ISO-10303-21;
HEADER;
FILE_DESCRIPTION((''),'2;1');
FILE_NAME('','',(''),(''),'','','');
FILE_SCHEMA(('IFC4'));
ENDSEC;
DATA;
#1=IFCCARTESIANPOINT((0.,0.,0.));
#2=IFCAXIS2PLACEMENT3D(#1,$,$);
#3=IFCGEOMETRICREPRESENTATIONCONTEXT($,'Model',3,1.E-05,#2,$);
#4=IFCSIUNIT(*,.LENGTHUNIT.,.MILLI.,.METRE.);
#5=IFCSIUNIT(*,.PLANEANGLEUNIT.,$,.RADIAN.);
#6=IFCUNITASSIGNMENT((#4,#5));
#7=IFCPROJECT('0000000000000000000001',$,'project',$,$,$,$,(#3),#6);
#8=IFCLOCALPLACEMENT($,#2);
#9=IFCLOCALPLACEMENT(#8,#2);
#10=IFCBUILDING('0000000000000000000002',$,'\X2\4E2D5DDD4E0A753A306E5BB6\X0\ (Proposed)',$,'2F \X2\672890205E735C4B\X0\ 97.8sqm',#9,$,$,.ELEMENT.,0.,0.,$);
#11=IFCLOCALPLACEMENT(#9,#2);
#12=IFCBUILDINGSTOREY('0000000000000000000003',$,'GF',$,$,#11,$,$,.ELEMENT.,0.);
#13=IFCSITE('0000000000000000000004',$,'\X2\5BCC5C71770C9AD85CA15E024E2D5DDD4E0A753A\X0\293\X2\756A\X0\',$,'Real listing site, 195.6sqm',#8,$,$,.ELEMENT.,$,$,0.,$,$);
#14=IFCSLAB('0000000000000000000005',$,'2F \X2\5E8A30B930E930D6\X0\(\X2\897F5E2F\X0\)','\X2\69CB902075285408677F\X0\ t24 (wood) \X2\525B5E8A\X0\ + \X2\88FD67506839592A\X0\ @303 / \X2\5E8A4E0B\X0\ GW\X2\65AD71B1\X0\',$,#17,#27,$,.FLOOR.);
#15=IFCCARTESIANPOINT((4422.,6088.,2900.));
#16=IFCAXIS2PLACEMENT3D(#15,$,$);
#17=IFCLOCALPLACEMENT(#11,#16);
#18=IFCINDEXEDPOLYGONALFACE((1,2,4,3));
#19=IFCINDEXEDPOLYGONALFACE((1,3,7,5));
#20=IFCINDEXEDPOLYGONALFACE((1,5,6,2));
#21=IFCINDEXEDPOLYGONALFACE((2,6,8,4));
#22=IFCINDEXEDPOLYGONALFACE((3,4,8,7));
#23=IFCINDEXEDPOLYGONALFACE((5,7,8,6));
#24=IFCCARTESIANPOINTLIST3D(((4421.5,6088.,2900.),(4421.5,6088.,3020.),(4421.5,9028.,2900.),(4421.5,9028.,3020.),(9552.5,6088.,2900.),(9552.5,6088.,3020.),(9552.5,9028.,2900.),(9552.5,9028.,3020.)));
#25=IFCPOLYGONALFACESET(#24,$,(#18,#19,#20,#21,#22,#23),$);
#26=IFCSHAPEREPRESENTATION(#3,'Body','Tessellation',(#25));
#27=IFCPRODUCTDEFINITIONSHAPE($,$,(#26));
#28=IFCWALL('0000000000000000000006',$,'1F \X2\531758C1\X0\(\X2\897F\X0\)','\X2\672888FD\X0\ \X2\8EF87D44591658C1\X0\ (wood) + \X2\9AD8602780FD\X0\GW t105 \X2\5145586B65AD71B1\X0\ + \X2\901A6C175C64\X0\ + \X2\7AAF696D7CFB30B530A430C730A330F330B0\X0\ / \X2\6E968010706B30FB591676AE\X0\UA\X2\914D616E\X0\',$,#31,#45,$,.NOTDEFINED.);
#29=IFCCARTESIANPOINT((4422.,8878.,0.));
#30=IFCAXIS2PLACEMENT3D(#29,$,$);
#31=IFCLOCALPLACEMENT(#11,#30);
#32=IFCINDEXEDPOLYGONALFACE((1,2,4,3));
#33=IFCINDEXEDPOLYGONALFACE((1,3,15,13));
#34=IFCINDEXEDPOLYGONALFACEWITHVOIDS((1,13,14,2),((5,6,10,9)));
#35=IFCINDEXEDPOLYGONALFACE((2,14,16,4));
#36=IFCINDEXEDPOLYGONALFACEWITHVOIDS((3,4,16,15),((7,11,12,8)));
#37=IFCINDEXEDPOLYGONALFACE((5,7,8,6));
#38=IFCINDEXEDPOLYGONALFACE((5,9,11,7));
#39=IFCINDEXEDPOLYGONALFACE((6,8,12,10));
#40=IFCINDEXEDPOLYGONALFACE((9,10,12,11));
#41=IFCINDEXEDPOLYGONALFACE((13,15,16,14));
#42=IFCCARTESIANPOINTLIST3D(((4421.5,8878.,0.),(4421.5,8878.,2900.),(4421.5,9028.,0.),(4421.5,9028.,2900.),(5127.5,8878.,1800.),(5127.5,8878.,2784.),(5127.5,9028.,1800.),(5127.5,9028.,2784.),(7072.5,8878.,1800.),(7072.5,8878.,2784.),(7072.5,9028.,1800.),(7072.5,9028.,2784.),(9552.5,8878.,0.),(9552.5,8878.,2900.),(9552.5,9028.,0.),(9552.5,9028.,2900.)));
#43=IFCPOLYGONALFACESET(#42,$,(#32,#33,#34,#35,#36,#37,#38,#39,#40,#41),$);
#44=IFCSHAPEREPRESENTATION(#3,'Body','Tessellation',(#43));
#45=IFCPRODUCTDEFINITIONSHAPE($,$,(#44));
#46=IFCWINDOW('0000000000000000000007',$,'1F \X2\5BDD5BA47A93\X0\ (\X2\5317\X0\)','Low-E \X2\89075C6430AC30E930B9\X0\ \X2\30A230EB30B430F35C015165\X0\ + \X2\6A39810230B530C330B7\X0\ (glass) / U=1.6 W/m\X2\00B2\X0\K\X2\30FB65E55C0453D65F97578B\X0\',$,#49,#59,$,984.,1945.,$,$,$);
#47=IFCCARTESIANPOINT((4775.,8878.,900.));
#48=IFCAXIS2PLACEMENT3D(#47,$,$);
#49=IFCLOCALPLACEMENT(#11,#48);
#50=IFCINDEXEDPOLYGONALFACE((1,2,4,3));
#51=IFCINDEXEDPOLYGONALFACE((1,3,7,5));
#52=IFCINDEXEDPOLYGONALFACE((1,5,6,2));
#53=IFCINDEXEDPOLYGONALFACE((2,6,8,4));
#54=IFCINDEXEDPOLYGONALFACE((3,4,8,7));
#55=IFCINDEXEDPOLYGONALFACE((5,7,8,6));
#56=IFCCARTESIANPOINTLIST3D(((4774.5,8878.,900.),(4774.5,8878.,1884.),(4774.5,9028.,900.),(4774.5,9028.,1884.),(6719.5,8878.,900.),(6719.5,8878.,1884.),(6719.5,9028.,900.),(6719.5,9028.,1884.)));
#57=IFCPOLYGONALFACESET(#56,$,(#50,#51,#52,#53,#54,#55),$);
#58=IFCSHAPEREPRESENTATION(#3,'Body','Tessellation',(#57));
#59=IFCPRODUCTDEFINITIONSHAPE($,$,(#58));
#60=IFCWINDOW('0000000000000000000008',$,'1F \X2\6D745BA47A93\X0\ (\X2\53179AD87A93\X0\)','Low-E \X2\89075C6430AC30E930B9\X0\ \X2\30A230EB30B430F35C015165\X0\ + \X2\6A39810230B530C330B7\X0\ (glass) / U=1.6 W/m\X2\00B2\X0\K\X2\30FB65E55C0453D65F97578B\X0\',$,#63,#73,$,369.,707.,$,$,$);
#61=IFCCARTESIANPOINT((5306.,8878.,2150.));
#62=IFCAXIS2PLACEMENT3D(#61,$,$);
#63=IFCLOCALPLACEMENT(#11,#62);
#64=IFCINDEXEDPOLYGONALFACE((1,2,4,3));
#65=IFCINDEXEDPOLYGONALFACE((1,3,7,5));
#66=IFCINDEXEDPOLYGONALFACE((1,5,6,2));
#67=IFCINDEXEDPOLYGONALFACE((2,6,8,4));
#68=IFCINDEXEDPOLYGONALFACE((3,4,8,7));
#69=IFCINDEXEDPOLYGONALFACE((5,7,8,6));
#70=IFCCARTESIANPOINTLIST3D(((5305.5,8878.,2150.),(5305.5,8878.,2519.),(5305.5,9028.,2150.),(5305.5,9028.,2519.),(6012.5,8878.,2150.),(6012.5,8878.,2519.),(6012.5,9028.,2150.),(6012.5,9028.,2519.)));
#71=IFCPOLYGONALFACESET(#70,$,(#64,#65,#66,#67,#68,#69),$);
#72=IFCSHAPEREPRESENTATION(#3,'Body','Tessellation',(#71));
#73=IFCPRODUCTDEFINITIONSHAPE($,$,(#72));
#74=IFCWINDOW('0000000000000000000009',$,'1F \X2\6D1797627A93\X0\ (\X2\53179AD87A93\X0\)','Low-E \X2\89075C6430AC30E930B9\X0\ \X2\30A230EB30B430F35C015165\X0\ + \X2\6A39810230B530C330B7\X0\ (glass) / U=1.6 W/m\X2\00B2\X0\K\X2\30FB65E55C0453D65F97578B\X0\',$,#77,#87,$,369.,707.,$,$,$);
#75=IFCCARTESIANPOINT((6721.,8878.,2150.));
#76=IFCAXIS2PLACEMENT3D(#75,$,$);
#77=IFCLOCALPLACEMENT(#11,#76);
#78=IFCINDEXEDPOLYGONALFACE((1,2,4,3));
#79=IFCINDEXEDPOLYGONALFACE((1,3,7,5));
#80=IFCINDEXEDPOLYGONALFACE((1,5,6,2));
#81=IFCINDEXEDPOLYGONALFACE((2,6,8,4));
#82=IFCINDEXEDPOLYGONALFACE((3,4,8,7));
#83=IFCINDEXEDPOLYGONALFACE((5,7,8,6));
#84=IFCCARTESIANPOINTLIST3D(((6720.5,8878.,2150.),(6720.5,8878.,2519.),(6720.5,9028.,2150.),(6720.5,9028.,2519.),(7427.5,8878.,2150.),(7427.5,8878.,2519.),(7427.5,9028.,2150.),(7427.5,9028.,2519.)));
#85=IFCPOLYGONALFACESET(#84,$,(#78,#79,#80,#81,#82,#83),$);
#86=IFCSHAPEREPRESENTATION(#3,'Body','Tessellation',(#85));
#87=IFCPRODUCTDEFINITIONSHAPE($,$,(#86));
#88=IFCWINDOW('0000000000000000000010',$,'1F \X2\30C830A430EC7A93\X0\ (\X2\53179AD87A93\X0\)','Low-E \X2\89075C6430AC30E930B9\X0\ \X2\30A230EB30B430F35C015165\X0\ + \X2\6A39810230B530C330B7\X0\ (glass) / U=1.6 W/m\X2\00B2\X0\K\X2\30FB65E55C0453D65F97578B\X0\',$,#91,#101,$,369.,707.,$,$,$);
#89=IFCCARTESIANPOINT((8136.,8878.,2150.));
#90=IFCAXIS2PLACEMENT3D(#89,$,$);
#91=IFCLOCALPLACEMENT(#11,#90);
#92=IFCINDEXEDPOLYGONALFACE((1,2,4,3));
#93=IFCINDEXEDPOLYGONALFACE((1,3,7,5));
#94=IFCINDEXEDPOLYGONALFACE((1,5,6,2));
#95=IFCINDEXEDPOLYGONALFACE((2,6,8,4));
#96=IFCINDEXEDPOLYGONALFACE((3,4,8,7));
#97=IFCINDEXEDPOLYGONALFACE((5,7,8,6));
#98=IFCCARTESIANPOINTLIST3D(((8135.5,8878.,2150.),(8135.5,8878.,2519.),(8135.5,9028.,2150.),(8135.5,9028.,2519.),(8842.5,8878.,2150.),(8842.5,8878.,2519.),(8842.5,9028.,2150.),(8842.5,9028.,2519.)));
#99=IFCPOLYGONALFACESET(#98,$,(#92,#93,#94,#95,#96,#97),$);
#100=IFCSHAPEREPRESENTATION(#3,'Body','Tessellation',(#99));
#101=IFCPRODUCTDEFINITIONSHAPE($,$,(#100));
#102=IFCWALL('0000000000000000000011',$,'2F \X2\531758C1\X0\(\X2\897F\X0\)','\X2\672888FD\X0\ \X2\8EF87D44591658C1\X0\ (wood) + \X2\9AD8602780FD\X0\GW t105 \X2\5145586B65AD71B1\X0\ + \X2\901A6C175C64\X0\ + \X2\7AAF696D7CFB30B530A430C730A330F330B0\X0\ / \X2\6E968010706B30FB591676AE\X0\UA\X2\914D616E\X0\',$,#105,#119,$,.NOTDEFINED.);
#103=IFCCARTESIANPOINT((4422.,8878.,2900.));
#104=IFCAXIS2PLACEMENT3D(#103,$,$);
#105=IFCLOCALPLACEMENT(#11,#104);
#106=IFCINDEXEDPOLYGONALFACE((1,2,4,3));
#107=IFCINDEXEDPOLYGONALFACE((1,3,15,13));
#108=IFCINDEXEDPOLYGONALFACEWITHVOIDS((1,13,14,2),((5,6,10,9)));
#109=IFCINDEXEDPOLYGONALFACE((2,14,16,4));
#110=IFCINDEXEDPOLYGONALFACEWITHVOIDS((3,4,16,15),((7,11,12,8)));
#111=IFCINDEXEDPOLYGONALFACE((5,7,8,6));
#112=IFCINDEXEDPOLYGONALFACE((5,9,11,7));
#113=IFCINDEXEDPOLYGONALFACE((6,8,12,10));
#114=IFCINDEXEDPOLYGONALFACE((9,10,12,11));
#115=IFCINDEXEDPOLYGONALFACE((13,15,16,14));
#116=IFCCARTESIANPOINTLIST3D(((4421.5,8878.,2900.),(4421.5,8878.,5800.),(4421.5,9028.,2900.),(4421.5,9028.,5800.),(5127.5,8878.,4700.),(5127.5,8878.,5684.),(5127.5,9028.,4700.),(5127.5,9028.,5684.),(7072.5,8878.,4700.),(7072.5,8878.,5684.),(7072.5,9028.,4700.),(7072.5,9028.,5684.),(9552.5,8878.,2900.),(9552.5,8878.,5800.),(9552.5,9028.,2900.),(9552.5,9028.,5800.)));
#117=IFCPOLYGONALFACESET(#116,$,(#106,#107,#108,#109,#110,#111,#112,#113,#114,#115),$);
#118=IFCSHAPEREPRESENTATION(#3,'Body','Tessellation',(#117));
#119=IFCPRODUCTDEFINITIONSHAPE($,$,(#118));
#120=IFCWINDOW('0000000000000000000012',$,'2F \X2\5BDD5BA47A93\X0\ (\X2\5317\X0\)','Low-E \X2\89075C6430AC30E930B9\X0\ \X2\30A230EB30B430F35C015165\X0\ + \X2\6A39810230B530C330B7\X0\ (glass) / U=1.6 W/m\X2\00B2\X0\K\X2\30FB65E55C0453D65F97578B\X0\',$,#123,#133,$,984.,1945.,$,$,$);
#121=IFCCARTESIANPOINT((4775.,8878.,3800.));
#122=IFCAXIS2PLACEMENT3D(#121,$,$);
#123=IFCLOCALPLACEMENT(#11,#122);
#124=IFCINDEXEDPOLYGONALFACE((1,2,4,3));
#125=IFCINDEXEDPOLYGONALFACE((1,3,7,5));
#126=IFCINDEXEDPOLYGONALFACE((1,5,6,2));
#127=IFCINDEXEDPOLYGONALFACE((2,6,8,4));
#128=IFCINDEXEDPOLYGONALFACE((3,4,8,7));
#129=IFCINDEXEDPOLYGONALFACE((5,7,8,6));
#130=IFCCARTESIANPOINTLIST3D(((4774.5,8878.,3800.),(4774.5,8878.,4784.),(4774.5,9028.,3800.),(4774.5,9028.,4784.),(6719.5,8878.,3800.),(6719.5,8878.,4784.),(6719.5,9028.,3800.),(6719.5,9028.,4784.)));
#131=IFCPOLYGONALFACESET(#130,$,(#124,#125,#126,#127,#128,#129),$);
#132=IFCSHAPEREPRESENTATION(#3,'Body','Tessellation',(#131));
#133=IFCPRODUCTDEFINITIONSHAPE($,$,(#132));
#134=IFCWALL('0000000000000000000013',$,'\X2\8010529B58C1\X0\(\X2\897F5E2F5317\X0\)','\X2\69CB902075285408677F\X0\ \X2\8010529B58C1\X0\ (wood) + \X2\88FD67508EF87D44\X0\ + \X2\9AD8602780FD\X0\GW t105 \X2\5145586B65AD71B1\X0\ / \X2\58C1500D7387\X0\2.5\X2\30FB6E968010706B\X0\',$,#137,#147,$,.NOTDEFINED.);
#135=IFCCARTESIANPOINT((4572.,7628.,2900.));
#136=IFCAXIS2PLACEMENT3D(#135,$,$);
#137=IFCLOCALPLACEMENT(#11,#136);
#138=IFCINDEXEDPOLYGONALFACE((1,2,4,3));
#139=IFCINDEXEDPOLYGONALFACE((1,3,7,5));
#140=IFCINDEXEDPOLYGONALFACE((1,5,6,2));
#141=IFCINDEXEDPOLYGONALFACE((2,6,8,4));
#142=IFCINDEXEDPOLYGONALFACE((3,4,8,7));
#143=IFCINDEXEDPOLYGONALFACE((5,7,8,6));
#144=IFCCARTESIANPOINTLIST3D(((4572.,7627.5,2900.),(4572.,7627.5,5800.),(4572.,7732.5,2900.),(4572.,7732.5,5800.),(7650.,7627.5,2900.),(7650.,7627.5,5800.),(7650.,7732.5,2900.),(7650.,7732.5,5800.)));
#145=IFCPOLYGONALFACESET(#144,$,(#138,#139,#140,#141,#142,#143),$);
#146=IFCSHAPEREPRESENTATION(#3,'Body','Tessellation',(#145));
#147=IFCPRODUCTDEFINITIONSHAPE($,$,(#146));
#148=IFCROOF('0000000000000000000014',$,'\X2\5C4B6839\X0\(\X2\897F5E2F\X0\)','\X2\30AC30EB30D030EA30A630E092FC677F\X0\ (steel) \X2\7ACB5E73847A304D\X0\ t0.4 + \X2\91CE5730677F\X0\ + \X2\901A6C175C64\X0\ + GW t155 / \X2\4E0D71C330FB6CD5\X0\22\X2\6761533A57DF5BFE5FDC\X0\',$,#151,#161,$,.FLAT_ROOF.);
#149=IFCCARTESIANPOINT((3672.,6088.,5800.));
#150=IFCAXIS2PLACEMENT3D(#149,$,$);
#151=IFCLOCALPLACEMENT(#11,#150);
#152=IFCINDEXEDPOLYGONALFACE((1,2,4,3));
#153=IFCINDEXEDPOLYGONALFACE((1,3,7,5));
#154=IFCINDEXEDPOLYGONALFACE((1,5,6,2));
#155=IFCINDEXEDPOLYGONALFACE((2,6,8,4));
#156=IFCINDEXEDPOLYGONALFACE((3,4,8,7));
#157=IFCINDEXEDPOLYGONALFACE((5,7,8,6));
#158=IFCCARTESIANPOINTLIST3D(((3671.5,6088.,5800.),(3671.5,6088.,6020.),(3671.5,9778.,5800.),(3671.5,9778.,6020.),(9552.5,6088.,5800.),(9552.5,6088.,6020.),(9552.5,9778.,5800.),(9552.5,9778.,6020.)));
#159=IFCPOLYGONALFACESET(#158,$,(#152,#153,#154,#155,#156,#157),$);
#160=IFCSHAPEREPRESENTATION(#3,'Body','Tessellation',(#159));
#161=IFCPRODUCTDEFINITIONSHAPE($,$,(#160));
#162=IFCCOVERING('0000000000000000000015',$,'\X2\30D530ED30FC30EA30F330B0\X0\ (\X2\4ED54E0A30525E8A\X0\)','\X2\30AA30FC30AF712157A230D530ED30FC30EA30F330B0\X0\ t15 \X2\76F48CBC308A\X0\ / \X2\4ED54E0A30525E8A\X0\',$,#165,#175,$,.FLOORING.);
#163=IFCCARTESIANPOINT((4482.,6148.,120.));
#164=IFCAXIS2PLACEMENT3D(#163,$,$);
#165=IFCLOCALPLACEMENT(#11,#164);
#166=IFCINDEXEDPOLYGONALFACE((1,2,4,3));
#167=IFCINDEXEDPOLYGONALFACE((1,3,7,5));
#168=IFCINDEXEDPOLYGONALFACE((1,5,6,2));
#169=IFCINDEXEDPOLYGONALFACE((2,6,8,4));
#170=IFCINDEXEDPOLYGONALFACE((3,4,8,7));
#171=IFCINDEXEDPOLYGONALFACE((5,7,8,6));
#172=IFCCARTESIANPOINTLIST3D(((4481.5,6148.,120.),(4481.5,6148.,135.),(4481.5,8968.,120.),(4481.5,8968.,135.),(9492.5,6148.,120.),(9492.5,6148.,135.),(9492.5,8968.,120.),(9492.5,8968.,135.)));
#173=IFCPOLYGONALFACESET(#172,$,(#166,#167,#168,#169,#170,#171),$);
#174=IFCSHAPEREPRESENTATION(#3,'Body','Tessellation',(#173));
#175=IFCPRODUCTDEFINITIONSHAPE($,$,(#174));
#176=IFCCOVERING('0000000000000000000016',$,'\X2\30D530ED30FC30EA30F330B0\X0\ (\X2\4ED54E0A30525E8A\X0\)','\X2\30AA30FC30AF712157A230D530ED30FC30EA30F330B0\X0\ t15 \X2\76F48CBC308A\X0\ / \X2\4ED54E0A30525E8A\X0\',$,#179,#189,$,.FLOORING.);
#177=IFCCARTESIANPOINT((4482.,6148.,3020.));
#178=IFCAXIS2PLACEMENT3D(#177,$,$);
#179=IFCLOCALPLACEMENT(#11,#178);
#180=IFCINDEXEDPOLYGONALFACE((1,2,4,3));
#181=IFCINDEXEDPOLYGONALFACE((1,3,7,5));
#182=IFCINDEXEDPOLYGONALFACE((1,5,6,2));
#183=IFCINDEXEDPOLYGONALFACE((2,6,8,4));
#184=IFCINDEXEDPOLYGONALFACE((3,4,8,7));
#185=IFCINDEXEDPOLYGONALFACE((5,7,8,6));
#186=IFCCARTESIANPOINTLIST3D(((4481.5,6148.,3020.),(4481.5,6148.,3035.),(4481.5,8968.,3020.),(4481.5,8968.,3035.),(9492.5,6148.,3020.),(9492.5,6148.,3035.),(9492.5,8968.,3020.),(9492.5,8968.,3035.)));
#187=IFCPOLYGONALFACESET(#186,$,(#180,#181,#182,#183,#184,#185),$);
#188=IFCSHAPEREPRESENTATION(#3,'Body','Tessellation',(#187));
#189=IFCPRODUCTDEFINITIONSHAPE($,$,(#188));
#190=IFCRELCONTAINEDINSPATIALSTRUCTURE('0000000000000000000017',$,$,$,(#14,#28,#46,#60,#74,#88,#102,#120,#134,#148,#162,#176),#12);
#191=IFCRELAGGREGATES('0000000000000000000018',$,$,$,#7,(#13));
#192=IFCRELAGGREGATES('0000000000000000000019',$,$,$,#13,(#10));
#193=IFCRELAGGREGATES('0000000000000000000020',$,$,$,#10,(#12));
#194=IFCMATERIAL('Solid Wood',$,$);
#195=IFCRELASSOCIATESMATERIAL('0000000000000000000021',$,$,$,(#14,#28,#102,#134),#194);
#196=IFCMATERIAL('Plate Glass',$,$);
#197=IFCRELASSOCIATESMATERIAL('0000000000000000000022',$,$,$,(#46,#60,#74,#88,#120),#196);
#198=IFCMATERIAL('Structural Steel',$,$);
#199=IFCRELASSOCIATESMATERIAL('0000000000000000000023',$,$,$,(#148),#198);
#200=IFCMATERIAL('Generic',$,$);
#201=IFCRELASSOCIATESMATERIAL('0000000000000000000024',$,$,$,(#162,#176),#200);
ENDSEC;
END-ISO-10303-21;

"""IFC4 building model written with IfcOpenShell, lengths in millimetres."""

from ifc_helpers import new_model, si_unit, frame, frame_2d, origin, place, context, project, spatial, rectangle, extrude, material, element, fill, save


model = new_model("IFC4")

# Units and contexts
model_context = context("Model", 3, precision=1e-05, world=origin())
ifc_project = project(units=[si_unit("LENGTHUNIT", "METRE", prefix="MILLI"), si_unit("PLANEANGLEUNIT", "RADIAN")], contexts=[model_context])

# Site, building, storey
site_placement = place(None, origin())
site = spatial("IfcSite", under=ifc_project, at=site_placement, Name="富山県高岡市中川上町293番", ObjectType="Real listing site, 195.6sqm", CompositionType="ELEMENT", RefElevation=0.0)
building_placement = place(site_placement, origin())
building = spatial("IfcBuilding", under=site, at=building_placement, Name="中川上町の家 (Proposed)", ObjectType="2F 木造平屋 97.8sqm", CompositionType="ELEMENT", ElevationOfRefHeight=0.0, ElevationOfTerrain=0.0)
storey_placement = place(building_placement, origin())
storey = spatial("IfcBuildingStorey", under=building, at=storey_placement, Name="GF", CompositionType="ELEMENT", Elevation=0.0)

# Slab
ifc_material_1 = material(Name="Solid Wood")
slab_1_placement = place(storey_placement, frame((4422.0, 6088.0, 2900.0)))
element("IfcSlab", 1, at=slab_1_placement, inside=storey, material=ifc_material_1, Name="2F 床スラブ(西帯)", Description="構造用合板 t24 (wood) 剛床 + 製材根太 @303 / 床下 GW断熱", PredefinedType="FLOOR", context=model_context, shape_type="SweptSolid", body=[
    extrude(rectangle(XDim=5131.0, YDim=2940.0, at=frame_2d((2565.0, 1470.0))), frame((4422.0, 6088.0, 2900.0)), (0.0, 0.0, 1.0), 120.0),
])

# Wall, openings, windows
wall_1_placement = place(storey_placement, frame((4422.0, 8878.0, 0.0)))
wall_1 = element("IfcWall", 2, at=wall_1_placement, inside=storey, material=ifc_material_1, Name="1F 北壁(西)", Description="木製 軸組外壁 (wood) + 高性能GW t105 充填断熱 + 通気層 + 窯業系サイディング / 準耐火・外皮UA配慮", PredefinedType="NOTDEFINED", context=model_context, shape_type="SweptSolid", body=[
    extrude(rectangle(XDim=5131.0, YDim=150.0, at=frame_2d((2565.0, 75.0))), frame((4422.0, 8878.0, 0.0)), (0.0, 0.0, 1.0), 2900.0),
])
opening_1_placement = place(storey_placement, frame((4775.0, 8878.0, 900.0)))
opening_1 = element("IfcOpeningElement", 3, at=opening_1_placement, cuts=wall_1, PredefinedType="NOTDEFINED", context=model_context, shape_type="SweptSolid", body=[
    extrude(rectangle(XDim=1945.0, YDim=150.0, at=frame_2d((972.0, 75.0))), frame((4775.0, 8878.0, 900.0)), (0.0, 0.0, 1.0), 984.0),
])
opening_2_placement = place(storey_placement, frame((5306.0, 8878.0, 2150.0)))
opening_2 = element("IfcOpeningElement", 4, at=opening_2_placement, cuts=wall_1, PredefinedType="NOTDEFINED", context=model_context, shape_type="SweptSolid", body=[
    extrude(rectangle(XDim=707.0, YDim=150.0, at=frame_2d((353.0, 75.0))), frame((5306.0, 8878.0, 2150.0)), (0.0, 0.0, 1.0), 369.0),
])
opening_3_placement = place(storey_placement, frame((6721.0, 8878.0, 2150.0)))
opening_3 = element("IfcOpeningElement", 5, at=opening_3_placement, cuts=wall_1, PredefinedType="NOTDEFINED", context=model_context, shape_type="SweptSolid", body=[
    extrude(rectangle(XDim=707.0, YDim=150.0, at=frame_2d((353.0, 75.0))), frame((6721.0, 8878.0, 2150.0)), (0.0, 0.0, 1.0), 369.0),
])
opening_4_placement = place(storey_placement, frame((8136.0, 8878.0, 2150.0)))
opening_4 = element("IfcOpeningElement", 6, at=opening_4_placement, cuts=wall_1, PredefinedType="NOTDEFINED", context=model_context, shape_type="SweptSolid", body=[
    extrude(rectangle(XDim=707.0, YDim=150.0, at=frame_2d((353.0, 75.0))), frame((8136.0, 8878.0, 2150.0)), (0.0, 0.0, 1.0), 369.0),
])
ifc_material_2 = material(Name="Plate Glass")
window_1_placement = place(storey_placement, frame((4775.0, 8878.0, 900.0)))
window_1 = element("IfcWindow", 7, at=window_1_placement, inside=storey, material=ifc_material_2, Name="1F 寝室窓 (北)", Description="Low-E 複層ガラス アルゴン封入 + 樹脂サッシ (glass) / U=1.6 W/m²K・日射取得型", OverallHeight=984.0, OverallWidth=1945.0, context=model_context, shape_type="SweptSolid", body=[
    extrude(rectangle(XDim=1945.0, YDim=150.0, at=frame_2d((972.0, 75.0))), frame((4775.0, 8878.0, 900.0)), (0.0, 0.0, 1.0), 984.0),
])
fill(opening_1, window_1)
window_2_placement = place(storey_placement, frame((5306.0, 8878.0, 2150.0)))
window_2 = element("IfcWindow", 8, at=window_2_placement, inside=storey, material=ifc_material_2, Name="1F 浴室窓 (北高窓)", Description="Low-E 複層ガラス アルゴン封入 + 樹脂サッシ (glass) / U=1.6 W/m²K・日射取得型", OverallHeight=369.0, OverallWidth=707.0, context=model_context, shape_type="SweptSolid", body=[
    extrude(rectangle(XDim=707.0, YDim=150.0, at=frame_2d((353.0, 75.0))), frame((5306.0, 8878.0, 2150.0)), (0.0, 0.0, 1.0), 369.0),
])
fill(opening_2, window_2)
window_3_placement = place(storey_placement, frame((6721.0, 8878.0, 2150.0)))
window_3 = element("IfcWindow", 9, at=window_3_placement, inside=storey, material=ifc_material_2, Name="1F 洗面窓 (北高窓)", Description="Low-E 複層ガラス アルゴン封入 + 樹脂サッシ (glass) / U=1.6 W/m²K・日射取得型", OverallHeight=369.0, OverallWidth=707.0, context=model_context, shape_type="SweptSolid", body=[
    extrude(rectangle(XDim=707.0, YDim=150.0, at=frame_2d((353.0, 75.0))), frame((6721.0, 8878.0, 2150.0)), (0.0, 0.0, 1.0), 369.0),
])
fill(opening_3, window_3)
window_4_placement = place(storey_placement, frame((8136.0, 8878.0, 2150.0)))
window_4 = element("IfcWindow", 10, at=window_4_placement, inside=storey, material=ifc_material_2, Name="1F トイレ窓 (北高窓)", Description="Low-E 複層ガラス アルゴン封入 + 樹脂サッシ (glass) / U=1.6 W/m²K・日射取得型", OverallHeight=369.0, OverallWidth=707.0, context=model_context, shape_type="SweptSolid", body=[
    extrude(rectangle(XDim=707.0, YDim=150.0, at=frame_2d((353.0, 75.0))), frame((8136.0, 8878.0, 2150.0)), (0.0, 0.0, 1.0), 369.0),
])
fill(opening_4, window_4)

# Wall, opening, window
wall_2_placement = place(storey_placement, frame((4422.0, 8878.0, 2900.0)))
wall_2 = element("IfcWall", 11, at=wall_2_placement, inside=storey, material=ifc_material_1, Name="2F 北壁(西)", Description="木製 軸組外壁 (wood) + 高性能GW t105 充填断熱 + 通気層 + 窯業系サイディング / 準耐火・外皮UA配慮", PredefinedType="NOTDEFINED", context=model_context, shape_type="SweptSolid", body=[
    extrude(rectangle(XDim=5131.0, YDim=150.0, at=frame_2d((2565.0, 75.0))), frame((4422.0, 8878.0, 2900.0)), (0.0, 0.0, 1.0), 2900.0),
])
opening_5_placement = place(storey_placement, frame((4775.0, 8878.0, 3800.0)))
opening_5 = element("IfcOpeningElement", 12, at=opening_5_placement, cuts=wall_2, PredefinedType="NOTDEFINED", context=model_context, shape_type="SweptSolid", body=[
    extrude(rectangle(XDim=1945.0, YDim=150.0, at=frame_2d((972.0, 75.0))), frame((4775.0, 8878.0, 3800.0)), (0.0, 0.0, 1.0), 984.0),
])
window_5_placement = place(storey_placement, frame((4775.0, 8878.0, 3800.0)))
window_5 = element("IfcWindow", 13, at=window_5_placement, inside=storey, material=ifc_material_2, Name="2F 寝室窓 (北)", Description="Low-E 複層ガラス アルゴン封入 + 樹脂サッシ (glass) / U=1.6 W/m²K・日射取得型", OverallHeight=984.0, OverallWidth=1945.0, context=model_context, shape_type="SweptSolid", body=[
    extrude(rectangle(XDim=1945.0, YDim=150.0, at=frame_2d((972.0, 75.0))), frame((4775.0, 8878.0, 3800.0)), (0.0, 0.0, 1.0), 984.0),
])
fill(opening_5, window_5)

# Wall
wall_3_placement = place(storey_placement, frame((4572.0, 7628.0, 2900.0)))
element("IfcWall", 14, at=wall_3_placement, inside=storey, material=ifc_material_1, Name="耐力壁(西帯北)", Description="構造用合板 耐力壁 (wood) + 製材軸組 + 高性能GW t105 充填断熱 / 壁倍率2.5・準耐火", PredefinedType="NOTDEFINED", context=model_context, shape_type="SweptSolid", body=[
    extrude(rectangle(XDim=3078.0, YDim=105.0, at=frame_2d((1539.0, 52.0))), frame((4572.0, 7628.0, 2900.0)), (0.0, 0.0, 1.0), 2900.0),
])

# Roof
ifc_material_3 = material(Name="Structural Steel")
for number, where, name in (
    (15, (3672.0, 6088.0, 5800.0), "屋根(西帯)"),
):
    element("IfcRoof", number, at=place(storey_placement, frame(where)), inside=storey, material=ifc_material_3, Name=name, Description="ガルバリウム鋼板 (steel) 立平葺き t0.4 + 野地板 + 通気層 + GW t155 / 不燃・法22条区域対応", PredefinedType="FLAT_ROOF", context=model_context, shape_type="SweptSolid", body=[
        extrude(rectangle(XDim=5881.0, YDim=3690.0, at=frame_2d((2940.0, 1845.0))), frame((3672.0, 6088.0, 5800.0)), (0.0, 0.0, 1.0), 220.0),
    ])

# Coverings
ifc_material_4 = material(Name="Generic")
covering_1_placement = place(storey_placement, frame((4482.0, 6148.0, 120.0)))
element("IfcCovering", 16, at=covering_1_placement, inside=storey, material=ifc_material_4, Name="フローリング (仕上げ床)", Description="オーク無垢フローリング t15 直貼り / 仕上げ床", PredefinedType="FLOORING", context=model_context, shape_type="SweptSolid", body=[
    extrude(rectangle(XDim=5011.0, YDim=2820.0, at=frame_2d((2505.0, 1410.0))), frame((4482.0, 6148.0, 120.0)), (0.0, 0.0, 1.0), 15.0),
])
covering_2_placement = place(storey_placement, frame((4482.0, 6148.0, 3020.0)))
element("IfcCovering", 17, at=covering_2_placement, inside=storey, material=ifc_material_4, Name="フローリング (仕上げ床)", Description="オーク無垢フローリング t15 直貼り / 仕上げ床", PredefinedType="FLOORING", context=model_context, shape_type="SweptSolid", body=[
    extrude(rectangle(XDim=5011.0, YDim=2820.0, at=frame_2d((2505.0, 1410.0))), frame((4482.0, 6148.0, 3020.0)), (0.0, 0.0, 1.0), 15.0),
])

save(model, "model.ifc")
